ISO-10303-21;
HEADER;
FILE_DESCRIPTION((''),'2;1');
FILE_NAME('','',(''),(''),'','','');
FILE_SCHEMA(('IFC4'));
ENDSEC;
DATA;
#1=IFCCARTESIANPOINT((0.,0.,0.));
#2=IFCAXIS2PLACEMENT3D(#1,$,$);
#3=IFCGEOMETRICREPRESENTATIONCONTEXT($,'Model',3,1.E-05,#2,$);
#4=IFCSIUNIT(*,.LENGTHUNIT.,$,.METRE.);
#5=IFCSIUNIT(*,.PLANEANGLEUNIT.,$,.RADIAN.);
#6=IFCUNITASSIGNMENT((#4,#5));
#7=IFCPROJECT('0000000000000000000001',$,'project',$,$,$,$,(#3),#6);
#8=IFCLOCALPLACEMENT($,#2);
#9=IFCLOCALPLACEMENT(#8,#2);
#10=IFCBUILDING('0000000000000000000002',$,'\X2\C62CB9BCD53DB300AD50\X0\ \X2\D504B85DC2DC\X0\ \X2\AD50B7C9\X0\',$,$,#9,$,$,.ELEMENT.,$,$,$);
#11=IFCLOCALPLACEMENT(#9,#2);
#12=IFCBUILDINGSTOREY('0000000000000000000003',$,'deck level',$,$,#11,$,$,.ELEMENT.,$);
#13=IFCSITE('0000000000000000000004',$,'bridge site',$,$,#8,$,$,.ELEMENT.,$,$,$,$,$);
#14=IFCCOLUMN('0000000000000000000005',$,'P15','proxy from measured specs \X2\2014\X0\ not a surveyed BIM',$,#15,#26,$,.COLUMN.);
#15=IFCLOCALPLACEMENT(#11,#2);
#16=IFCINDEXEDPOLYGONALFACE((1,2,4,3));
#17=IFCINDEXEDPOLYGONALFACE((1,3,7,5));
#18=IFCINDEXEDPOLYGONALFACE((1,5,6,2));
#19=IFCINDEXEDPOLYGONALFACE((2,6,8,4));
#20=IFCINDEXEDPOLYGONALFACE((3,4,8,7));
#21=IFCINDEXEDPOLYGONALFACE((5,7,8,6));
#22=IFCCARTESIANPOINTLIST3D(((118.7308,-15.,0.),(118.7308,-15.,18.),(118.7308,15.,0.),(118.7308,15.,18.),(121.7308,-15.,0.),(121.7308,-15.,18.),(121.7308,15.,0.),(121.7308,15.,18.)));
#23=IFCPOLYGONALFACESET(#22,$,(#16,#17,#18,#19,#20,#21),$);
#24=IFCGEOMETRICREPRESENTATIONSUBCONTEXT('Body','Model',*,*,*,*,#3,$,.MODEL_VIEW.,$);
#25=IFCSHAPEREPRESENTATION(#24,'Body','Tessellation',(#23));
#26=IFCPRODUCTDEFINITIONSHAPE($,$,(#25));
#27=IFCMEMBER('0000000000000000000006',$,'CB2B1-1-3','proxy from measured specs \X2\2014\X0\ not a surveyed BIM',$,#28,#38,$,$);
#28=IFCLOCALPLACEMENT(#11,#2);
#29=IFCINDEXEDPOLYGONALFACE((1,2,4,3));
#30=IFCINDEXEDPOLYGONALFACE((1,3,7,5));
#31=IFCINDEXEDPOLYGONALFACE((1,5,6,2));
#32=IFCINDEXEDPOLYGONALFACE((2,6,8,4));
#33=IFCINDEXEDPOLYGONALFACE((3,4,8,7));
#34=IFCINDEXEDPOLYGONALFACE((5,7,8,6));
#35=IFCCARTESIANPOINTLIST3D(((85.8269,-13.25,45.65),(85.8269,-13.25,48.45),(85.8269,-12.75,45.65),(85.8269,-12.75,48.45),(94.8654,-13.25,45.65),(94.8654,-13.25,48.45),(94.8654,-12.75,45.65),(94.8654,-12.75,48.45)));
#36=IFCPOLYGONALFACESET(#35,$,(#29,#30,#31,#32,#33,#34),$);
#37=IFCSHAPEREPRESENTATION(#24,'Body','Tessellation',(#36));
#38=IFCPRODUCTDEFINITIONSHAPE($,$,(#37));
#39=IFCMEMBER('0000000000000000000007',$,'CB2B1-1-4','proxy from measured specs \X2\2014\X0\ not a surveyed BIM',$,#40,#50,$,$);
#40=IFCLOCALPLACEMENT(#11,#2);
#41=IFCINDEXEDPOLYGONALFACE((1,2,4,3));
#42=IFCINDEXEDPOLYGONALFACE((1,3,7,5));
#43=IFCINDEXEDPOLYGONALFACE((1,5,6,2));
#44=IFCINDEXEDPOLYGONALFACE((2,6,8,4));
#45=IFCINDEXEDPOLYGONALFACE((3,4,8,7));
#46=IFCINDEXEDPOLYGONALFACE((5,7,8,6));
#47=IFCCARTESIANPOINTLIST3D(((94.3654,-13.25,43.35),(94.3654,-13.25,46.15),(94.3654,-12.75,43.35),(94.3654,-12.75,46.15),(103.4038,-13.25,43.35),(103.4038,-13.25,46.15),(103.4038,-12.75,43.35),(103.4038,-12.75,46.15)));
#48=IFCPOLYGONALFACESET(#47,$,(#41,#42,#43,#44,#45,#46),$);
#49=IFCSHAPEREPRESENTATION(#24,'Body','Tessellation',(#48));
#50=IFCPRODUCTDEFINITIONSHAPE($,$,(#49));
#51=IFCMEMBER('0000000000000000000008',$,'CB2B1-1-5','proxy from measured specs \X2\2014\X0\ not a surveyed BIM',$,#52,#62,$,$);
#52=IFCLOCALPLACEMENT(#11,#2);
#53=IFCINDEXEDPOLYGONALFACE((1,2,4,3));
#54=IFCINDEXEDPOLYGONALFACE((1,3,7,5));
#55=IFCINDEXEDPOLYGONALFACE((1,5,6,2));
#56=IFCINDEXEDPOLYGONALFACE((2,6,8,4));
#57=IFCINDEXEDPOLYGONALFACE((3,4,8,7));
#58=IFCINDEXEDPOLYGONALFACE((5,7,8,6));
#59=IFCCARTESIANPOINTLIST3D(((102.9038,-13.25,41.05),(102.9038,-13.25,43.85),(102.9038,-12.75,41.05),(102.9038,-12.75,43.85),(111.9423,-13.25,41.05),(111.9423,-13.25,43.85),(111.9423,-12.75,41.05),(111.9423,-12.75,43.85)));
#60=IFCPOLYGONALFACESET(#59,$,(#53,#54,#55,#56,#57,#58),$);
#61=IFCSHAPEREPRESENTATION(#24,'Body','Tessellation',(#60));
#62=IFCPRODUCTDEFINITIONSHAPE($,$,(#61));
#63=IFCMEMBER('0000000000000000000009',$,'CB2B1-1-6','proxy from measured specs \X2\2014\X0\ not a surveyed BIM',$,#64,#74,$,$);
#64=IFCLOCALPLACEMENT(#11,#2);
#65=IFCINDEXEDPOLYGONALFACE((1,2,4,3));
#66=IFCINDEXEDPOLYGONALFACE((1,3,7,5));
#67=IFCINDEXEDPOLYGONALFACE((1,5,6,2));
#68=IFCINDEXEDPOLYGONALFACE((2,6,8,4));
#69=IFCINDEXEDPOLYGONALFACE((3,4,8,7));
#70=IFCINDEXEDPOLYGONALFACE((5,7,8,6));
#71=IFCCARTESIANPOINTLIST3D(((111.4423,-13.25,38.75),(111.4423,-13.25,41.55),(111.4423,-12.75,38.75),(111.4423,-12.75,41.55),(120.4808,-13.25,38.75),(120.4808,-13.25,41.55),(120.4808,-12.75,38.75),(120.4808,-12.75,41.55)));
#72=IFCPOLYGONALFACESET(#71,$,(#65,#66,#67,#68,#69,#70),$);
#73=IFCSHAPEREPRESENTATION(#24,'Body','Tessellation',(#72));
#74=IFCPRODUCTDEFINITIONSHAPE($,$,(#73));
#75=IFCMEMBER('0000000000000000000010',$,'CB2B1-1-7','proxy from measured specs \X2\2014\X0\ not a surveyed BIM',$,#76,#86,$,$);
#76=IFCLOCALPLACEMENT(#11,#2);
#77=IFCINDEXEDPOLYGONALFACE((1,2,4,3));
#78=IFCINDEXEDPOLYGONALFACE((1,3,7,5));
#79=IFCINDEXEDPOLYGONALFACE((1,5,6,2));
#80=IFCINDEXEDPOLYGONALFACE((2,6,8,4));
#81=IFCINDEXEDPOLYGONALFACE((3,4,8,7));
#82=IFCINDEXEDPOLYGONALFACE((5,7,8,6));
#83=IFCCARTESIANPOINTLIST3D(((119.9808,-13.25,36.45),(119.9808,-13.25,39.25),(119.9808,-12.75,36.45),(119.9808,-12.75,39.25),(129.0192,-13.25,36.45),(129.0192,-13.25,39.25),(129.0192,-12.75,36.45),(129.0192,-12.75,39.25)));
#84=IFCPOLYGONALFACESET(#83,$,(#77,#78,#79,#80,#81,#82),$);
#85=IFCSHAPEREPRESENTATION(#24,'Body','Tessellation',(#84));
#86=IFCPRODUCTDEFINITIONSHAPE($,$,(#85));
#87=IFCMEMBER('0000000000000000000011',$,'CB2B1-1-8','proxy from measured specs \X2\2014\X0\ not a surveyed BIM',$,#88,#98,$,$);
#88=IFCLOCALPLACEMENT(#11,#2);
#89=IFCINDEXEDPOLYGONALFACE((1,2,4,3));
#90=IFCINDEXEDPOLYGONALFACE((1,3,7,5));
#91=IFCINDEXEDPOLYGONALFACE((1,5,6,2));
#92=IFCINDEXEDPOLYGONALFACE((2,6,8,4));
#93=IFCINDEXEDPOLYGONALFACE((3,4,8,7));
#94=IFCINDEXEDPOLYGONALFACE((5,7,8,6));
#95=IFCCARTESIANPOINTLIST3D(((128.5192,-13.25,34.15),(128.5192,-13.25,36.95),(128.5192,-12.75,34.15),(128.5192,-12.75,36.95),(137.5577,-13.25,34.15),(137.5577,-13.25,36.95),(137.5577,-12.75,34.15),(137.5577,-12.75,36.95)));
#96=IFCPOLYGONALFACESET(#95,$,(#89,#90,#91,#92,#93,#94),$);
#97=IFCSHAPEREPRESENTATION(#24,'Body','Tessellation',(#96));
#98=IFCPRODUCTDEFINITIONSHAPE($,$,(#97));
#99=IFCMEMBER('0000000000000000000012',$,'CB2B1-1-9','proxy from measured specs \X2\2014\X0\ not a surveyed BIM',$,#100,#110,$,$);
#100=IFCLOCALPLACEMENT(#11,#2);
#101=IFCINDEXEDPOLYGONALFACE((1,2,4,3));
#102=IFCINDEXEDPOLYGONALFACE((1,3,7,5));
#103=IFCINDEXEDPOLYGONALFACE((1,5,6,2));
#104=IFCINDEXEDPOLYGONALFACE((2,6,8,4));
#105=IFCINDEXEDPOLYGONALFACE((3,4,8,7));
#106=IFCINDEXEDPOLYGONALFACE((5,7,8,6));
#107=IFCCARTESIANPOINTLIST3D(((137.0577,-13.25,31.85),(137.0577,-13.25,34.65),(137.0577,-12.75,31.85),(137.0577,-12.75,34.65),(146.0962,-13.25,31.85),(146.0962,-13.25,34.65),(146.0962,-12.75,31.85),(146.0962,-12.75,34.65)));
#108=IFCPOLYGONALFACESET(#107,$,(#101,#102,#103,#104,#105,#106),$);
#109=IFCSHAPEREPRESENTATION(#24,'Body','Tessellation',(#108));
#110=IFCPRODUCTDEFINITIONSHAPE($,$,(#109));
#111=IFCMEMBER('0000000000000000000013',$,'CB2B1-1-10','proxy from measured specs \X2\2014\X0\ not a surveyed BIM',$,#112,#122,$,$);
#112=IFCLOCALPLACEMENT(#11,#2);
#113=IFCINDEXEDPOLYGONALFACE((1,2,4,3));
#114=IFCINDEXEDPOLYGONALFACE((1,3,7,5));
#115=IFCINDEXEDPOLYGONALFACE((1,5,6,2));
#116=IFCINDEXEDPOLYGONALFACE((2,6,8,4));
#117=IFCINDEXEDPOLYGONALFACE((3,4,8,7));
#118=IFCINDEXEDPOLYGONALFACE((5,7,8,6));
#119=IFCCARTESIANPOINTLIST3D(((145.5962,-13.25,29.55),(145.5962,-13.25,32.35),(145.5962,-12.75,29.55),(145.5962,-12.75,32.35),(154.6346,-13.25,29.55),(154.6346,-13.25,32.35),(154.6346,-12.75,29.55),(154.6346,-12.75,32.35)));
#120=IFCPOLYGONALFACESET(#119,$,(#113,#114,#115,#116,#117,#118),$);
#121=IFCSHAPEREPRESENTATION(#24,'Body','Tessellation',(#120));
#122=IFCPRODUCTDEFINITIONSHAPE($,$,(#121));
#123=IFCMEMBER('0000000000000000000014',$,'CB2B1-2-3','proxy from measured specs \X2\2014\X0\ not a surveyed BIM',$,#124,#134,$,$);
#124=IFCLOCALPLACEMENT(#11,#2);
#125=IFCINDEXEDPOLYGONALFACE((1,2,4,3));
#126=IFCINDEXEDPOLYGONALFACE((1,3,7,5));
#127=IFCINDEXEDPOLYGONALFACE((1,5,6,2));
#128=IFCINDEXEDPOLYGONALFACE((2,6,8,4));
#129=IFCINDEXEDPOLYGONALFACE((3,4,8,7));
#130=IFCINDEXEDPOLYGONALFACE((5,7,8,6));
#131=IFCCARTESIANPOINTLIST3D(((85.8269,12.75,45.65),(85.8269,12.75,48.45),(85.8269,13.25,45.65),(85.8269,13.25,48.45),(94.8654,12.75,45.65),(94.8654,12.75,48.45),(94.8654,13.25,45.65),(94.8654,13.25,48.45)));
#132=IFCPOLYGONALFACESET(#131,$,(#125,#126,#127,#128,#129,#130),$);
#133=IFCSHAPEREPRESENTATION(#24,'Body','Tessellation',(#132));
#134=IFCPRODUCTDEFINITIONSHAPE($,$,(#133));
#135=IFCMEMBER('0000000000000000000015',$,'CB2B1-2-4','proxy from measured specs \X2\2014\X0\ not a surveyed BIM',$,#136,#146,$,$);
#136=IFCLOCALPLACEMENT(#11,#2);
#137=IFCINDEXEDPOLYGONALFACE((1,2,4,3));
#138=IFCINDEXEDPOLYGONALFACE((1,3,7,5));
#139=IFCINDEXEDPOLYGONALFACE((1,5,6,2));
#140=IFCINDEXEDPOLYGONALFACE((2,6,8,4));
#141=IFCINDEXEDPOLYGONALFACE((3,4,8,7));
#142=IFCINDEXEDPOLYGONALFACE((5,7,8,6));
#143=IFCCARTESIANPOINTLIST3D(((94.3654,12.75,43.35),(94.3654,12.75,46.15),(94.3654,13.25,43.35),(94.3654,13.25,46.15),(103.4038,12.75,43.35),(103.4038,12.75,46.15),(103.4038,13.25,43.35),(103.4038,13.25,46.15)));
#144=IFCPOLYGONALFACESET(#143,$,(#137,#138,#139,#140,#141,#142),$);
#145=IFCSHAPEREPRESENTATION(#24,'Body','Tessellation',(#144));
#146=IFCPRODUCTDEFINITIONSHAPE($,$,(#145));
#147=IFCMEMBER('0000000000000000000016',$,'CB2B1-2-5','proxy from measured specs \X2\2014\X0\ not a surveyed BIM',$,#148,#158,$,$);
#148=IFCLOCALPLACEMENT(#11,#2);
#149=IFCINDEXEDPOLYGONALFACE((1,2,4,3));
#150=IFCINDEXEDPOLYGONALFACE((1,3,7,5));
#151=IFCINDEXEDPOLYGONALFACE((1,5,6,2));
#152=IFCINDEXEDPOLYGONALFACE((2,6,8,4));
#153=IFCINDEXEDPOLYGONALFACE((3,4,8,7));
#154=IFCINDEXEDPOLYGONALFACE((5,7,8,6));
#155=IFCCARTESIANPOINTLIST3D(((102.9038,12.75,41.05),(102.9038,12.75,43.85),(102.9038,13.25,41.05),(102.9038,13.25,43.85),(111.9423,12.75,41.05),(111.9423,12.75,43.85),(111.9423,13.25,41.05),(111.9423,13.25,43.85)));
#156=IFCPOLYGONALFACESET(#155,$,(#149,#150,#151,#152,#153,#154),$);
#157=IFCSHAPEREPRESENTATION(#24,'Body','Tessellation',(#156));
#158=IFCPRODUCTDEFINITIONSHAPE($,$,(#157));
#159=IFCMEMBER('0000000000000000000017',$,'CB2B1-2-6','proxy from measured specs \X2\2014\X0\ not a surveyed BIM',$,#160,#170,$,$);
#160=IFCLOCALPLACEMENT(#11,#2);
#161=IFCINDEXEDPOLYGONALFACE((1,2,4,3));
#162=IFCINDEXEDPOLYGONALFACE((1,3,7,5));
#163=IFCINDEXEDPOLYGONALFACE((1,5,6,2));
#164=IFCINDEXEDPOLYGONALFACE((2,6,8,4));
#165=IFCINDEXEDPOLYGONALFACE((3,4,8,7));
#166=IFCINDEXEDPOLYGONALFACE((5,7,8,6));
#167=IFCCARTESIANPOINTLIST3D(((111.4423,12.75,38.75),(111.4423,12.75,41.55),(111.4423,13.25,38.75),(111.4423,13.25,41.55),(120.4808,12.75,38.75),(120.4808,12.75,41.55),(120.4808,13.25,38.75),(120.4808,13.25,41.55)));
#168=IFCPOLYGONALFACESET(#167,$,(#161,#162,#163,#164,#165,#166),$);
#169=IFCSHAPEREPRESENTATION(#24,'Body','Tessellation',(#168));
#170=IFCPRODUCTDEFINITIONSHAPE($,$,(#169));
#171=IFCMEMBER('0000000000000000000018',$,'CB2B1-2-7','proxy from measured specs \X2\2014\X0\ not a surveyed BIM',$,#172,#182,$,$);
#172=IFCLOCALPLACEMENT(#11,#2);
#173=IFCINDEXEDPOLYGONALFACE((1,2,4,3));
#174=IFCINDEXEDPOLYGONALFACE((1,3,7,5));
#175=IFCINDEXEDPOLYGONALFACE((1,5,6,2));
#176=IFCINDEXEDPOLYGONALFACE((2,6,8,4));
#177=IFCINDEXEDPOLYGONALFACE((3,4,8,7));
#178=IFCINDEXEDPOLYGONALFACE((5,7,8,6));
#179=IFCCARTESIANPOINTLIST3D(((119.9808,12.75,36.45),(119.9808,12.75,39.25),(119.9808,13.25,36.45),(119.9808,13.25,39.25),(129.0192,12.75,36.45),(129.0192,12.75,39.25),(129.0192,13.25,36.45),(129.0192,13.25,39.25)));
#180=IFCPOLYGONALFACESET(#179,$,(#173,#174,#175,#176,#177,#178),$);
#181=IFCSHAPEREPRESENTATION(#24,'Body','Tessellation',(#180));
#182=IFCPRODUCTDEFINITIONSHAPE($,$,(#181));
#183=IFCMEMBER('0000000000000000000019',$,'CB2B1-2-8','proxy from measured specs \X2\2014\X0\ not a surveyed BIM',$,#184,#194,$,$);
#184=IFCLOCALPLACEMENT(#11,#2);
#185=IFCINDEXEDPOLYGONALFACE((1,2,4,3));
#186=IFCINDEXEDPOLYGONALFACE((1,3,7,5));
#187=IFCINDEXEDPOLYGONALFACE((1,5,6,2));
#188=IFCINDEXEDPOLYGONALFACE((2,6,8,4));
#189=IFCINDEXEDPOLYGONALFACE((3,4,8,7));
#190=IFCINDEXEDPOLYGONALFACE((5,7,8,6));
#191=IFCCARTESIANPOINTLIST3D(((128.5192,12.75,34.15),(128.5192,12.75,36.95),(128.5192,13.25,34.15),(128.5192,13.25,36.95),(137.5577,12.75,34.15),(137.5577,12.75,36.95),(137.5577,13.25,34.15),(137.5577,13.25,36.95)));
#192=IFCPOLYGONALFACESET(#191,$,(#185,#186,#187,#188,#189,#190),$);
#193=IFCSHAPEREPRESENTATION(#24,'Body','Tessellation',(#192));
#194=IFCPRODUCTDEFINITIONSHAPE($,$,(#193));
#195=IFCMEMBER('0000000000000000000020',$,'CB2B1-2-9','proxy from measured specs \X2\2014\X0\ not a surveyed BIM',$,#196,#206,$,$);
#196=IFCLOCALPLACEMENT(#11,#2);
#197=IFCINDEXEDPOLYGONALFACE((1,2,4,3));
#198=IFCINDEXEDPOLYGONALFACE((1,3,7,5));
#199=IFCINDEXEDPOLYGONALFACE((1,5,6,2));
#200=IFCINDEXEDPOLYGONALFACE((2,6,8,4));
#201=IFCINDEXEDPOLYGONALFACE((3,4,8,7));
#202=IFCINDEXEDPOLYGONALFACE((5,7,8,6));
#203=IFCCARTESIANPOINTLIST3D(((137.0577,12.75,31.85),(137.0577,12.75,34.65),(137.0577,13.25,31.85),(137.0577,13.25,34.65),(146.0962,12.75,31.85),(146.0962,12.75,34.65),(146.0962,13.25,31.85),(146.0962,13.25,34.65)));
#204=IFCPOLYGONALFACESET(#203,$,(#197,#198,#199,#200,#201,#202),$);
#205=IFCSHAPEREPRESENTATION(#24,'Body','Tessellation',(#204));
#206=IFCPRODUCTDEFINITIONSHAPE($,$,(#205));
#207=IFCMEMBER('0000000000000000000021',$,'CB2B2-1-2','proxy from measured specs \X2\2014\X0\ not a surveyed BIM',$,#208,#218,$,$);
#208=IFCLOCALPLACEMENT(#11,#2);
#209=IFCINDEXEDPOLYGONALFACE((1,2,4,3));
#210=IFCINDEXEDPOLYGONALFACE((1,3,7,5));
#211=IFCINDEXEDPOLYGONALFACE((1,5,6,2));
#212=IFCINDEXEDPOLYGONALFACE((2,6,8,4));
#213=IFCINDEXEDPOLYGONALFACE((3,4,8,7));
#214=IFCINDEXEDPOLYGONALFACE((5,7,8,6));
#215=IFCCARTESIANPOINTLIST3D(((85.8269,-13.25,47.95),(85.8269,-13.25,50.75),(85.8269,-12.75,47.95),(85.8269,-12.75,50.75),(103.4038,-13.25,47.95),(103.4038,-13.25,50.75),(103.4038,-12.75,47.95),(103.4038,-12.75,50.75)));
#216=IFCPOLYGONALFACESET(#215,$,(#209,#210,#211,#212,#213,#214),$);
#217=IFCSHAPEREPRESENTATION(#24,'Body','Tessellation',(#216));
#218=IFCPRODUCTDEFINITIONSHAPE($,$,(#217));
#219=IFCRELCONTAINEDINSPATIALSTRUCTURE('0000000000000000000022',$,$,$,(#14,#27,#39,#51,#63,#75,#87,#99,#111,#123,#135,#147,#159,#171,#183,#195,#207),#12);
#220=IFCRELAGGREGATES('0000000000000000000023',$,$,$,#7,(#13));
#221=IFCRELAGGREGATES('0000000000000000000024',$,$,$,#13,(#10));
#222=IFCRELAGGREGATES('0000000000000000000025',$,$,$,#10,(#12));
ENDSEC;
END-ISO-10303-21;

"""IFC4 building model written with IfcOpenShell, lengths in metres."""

from ifc_helpers import new_model, si_unit, frame, origin, origin_2d, place, context, subcontext, project, spatial, rectangle, extrude, element, save


model = new_model("IFC4")

# Units and contexts
model_context = context("Model", 3, precision=1e-05, world=origin())
body_context = subcontext(model_context, "Body", "Model", "MODEL_VIEW")
ifc_project = project(units=[si_unit("LENGTHUNIT", "METRE"), si_unit("PLANEANGLEUNIT", "RADIAN")], contexts=[model_context])

# Site, building, storey
site_placement = place(None, origin())
site = spatial("IfcSite", under=ifc_project, at=site_placement, Name="bridge site", CompositionType="ELEMENT")
building_placement = place(site_placement, origin())
building = spatial("IfcBuilding", under=site, at=building_placement, Name="올림픽대교 프록시 교량", CompositionType="ELEMENT")
storey_placement = place(building_placement, origin())
storey = spatial("IfcBuildingStorey", under=building, at=storey_placement, Name="deck level", CompositionType="ELEMENT")

# Column
column_placement = place(storey_placement, frame((120.2308, 0.0, 0.0)))
element("IfcColumn", 1, at=column_placement, inside=storey, Name="P15", Description="proxy from measured specs — not a surveyed BIM", PredefinedType="COLUMN", context=body_context, shape_type="SweptSolid", body=[
    extrude(rectangle(XDim=3.0, YDim=30.0, at=origin_2d()), origin(), (0.0, 0.0, 1.0), 18.0),
])

# Members
member_1_placement = place(storey_placement, frame((90.3462, -13.0, 45.65)))
element("IfcMember", 2, at=member_1_placement, inside=storey, Name="CB2B1-1-3", Description="proxy from measured specs — not a surveyed BIM", context=body_context, shape_type="SweptSolid", body=[
    extrude(rectangle(XDim=9.0385, YDim=0.5, at=origin_2d()), origin(), (0.0, 0.0, 1.0), 2.8),
])
member_2_placement = place(storey_placement, frame((98.8846, -13.0, 43.35)))
element("IfcMember", 3, at=member_2_placement, inside=storey, Name="CB2B1-1-4", Description="proxy from measured specs — not a surveyed BIM", context=body_context, shape_type="SweptSolid", body=[
    extrude(rectangle(XDim=9.0385, YDim=0.5, at=origin_2d()), origin(), (0.0, 0.0, 1.0), 2.8),
])
member_3_placement = place(storey_placement, frame((107.4231, -13.0, 41.05)))
element("IfcMember", 4, at=member_3_placement, inside=storey, Name="CB2B1-1-5", Description="proxy from measured specs — not a surveyed BIM", context=body_context, shape_type="SweptSolid", body=[
    extrude(rectangle(XDim=9.0385, YDim=0.5, at=origin_2d()), origin(), (0.0, 0.0, 1.0), 2.8),
])
for number, where, name in (
    (5, (115.9615, -13.0, 38.75), "CB2B1-1-6"),
    (6, (124.5, -13.0, 36.45), "CB2B1-1-7"),
):
    element("IfcMember", number, at=place(storey_placement, frame(where)), inside=storey, Name=name, Description="proxy from measured specs — not a surveyed BIM", context=body_context, shape_type="SweptSolid", body=[
        extrude(rectangle(XDim=9.0385, YDim=0.5, at=origin_2d()), origin(), (0.0, 0.0, 1.0), 2.8),
    ])
member_4_placement = place(storey_placement, frame((133.0385, -13.0, 34.15)))
element("IfcMember", 7, at=member_4_placement, inside=storey, Name="CB2B1-1-8", Description="proxy from measured specs — not a surveyed BIM", context=body_context, shape_type="SweptSolid", body=[
    extrude(rectangle(XDim=9.0385, YDim=0.5, at=origin_2d()), origin(), (0.0, 0.0, 1.0), 2.8),
])
member_5_placement = place(storey_placement, frame((141.5769, -13.0, 31.85)))
element("IfcMember", 8, at=member_5_placement, inside=storey, Name="CB2B1-1-9", Description="proxy from measured specs — not a surveyed BIM", context=body_context, shape_type="SweptSolid", body=[
    extrude(rectangle(XDim=9.0385, YDim=0.5, at=origin_2d()), origin(), (0.0, 0.0, 1.0), 2.8),
])
member_6_placement = place(storey_placement, frame((150.1154, -13.0, 29.55)))
element("IfcMember", 9, at=member_6_placement, inside=storey, Name="CB2B1-1-10", Description="proxy from measured specs — not a surveyed BIM", context=body_context, shape_type="SweptSolid", body=[
    extrude(rectangle(XDim=9.0385, YDim=0.5, at=origin_2d()), origin(), (0.0, 0.0, 1.0), 2.8),
])
member_7_placement = place(storey_placement, frame((90.3462, 13.0, 45.65)))
element("IfcMember", 10, at=member_7_placement, inside=storey, Name="CB2B1-2-3", Description="proxy from measured specs — not a surveyed BIM", context=body_context, shape_type="SweptSolid", body=[
    extrude(rectangle(XDim=9.0385, YDim=0.5, at=origin_2d()), origin(), (0.0, 0.0, 1.0), 2.8),
])
member_8_placement = place(storey_placement, frame((98.8846, 13.0, 43.35)))
element("IfcMember", 11, at=member_8_placement, inside=storey, Name="CB2B1-2-4", Description="proxy from measured specs — not a surveyed BIM", context=body_context, shape_type="SweptSolid", body=[
    extrude(rectangle(XDim=9.0385, YDim=0.5, at=origin_2d()), origin(), (0.0, 0.0, 1.0), 2.8),
])
member_9_placement = place(storey_placement, frame((107.4231, 13.0, 41.05)))
element("IfcMember", 12, at=member_9_placement, inside=storey, Name="CB2B1-2-5", Description="proxy from measured specs — not a surveyed BIM", context=body_context, shape_type="SweptSolid", body=[
    extrude(rectangle(XDim=9.0385, YDim=0.5, at=origin_2d()), origin(), (0.0, 0.0, 1.0), 2.8),
])
for number, where, name in (
    (13, (115.9615, 13.0, 38.75), "CB2B1-2-6"),
    (14, (124.5, 13.0, 36.45), "CB2B1-2-7"),
):
    element("IfcMember", number, at=place(storey_placement, frame(where)), inside=storey, Name=name, Description="proxy from measured specs — not a surveyed BIM", context=body_context, shape_type="SweptSolid", body=[
        extrude(rectangle(XDim=9.0385, YDim=0.5, at=origin_2d()), origin(), (0.0, 0.0, 1.0), 2.8),
    ])
member_10_placement = place(storey_placement, frame((133.0385, 13.0, 34.15)))
element("IfcMember", 15, at=member_10_placement, inside=storey, Name="CB2B1-2-8", Description="proxy from measured specs — not a surveyed BIM", context=body_context, shape_type="SweptSolid", body=[
    extrude(rectangle(XDim=9.0385, YDim=0.5, at=origin_2d()), origin(), (0.0, 0.0, 1.0), 2.8),
])
member_11_placement = place(storey_placement, frame((141.5769, 13.0, 31.85)))
element("IfcMember", 16, at=member_11_placement, inside=storey, Name="CB2B1-2-9", Description="proxy from measured specs — not a surveyed BIM", context=body_context, shape_type="SweptSolid", body=[
    extrude(rectangle(XDim=9.0385, YDim=0.5, at=origin_2d()), origin(), (0.0, 0.0, 1.0), 2.8),
])
member_12_placement = place(storey_placement, frame((94.6154, -13.0, 47.95)))
element("IfcMember", 17, at=member_12_placement, inside=storey, Name="CB2B2-1-2", Description="proxy from measured specs — not a surveyed BIM", context=body_context, shape_type="SweptSolid", body=[
    extrude(rectangle(XDim=17.5769, YDim=0.5, at=origin_2d()), origin(), (0.0, 0.0, 1.0), 2.8),
])

save(model, "model.ifc")
